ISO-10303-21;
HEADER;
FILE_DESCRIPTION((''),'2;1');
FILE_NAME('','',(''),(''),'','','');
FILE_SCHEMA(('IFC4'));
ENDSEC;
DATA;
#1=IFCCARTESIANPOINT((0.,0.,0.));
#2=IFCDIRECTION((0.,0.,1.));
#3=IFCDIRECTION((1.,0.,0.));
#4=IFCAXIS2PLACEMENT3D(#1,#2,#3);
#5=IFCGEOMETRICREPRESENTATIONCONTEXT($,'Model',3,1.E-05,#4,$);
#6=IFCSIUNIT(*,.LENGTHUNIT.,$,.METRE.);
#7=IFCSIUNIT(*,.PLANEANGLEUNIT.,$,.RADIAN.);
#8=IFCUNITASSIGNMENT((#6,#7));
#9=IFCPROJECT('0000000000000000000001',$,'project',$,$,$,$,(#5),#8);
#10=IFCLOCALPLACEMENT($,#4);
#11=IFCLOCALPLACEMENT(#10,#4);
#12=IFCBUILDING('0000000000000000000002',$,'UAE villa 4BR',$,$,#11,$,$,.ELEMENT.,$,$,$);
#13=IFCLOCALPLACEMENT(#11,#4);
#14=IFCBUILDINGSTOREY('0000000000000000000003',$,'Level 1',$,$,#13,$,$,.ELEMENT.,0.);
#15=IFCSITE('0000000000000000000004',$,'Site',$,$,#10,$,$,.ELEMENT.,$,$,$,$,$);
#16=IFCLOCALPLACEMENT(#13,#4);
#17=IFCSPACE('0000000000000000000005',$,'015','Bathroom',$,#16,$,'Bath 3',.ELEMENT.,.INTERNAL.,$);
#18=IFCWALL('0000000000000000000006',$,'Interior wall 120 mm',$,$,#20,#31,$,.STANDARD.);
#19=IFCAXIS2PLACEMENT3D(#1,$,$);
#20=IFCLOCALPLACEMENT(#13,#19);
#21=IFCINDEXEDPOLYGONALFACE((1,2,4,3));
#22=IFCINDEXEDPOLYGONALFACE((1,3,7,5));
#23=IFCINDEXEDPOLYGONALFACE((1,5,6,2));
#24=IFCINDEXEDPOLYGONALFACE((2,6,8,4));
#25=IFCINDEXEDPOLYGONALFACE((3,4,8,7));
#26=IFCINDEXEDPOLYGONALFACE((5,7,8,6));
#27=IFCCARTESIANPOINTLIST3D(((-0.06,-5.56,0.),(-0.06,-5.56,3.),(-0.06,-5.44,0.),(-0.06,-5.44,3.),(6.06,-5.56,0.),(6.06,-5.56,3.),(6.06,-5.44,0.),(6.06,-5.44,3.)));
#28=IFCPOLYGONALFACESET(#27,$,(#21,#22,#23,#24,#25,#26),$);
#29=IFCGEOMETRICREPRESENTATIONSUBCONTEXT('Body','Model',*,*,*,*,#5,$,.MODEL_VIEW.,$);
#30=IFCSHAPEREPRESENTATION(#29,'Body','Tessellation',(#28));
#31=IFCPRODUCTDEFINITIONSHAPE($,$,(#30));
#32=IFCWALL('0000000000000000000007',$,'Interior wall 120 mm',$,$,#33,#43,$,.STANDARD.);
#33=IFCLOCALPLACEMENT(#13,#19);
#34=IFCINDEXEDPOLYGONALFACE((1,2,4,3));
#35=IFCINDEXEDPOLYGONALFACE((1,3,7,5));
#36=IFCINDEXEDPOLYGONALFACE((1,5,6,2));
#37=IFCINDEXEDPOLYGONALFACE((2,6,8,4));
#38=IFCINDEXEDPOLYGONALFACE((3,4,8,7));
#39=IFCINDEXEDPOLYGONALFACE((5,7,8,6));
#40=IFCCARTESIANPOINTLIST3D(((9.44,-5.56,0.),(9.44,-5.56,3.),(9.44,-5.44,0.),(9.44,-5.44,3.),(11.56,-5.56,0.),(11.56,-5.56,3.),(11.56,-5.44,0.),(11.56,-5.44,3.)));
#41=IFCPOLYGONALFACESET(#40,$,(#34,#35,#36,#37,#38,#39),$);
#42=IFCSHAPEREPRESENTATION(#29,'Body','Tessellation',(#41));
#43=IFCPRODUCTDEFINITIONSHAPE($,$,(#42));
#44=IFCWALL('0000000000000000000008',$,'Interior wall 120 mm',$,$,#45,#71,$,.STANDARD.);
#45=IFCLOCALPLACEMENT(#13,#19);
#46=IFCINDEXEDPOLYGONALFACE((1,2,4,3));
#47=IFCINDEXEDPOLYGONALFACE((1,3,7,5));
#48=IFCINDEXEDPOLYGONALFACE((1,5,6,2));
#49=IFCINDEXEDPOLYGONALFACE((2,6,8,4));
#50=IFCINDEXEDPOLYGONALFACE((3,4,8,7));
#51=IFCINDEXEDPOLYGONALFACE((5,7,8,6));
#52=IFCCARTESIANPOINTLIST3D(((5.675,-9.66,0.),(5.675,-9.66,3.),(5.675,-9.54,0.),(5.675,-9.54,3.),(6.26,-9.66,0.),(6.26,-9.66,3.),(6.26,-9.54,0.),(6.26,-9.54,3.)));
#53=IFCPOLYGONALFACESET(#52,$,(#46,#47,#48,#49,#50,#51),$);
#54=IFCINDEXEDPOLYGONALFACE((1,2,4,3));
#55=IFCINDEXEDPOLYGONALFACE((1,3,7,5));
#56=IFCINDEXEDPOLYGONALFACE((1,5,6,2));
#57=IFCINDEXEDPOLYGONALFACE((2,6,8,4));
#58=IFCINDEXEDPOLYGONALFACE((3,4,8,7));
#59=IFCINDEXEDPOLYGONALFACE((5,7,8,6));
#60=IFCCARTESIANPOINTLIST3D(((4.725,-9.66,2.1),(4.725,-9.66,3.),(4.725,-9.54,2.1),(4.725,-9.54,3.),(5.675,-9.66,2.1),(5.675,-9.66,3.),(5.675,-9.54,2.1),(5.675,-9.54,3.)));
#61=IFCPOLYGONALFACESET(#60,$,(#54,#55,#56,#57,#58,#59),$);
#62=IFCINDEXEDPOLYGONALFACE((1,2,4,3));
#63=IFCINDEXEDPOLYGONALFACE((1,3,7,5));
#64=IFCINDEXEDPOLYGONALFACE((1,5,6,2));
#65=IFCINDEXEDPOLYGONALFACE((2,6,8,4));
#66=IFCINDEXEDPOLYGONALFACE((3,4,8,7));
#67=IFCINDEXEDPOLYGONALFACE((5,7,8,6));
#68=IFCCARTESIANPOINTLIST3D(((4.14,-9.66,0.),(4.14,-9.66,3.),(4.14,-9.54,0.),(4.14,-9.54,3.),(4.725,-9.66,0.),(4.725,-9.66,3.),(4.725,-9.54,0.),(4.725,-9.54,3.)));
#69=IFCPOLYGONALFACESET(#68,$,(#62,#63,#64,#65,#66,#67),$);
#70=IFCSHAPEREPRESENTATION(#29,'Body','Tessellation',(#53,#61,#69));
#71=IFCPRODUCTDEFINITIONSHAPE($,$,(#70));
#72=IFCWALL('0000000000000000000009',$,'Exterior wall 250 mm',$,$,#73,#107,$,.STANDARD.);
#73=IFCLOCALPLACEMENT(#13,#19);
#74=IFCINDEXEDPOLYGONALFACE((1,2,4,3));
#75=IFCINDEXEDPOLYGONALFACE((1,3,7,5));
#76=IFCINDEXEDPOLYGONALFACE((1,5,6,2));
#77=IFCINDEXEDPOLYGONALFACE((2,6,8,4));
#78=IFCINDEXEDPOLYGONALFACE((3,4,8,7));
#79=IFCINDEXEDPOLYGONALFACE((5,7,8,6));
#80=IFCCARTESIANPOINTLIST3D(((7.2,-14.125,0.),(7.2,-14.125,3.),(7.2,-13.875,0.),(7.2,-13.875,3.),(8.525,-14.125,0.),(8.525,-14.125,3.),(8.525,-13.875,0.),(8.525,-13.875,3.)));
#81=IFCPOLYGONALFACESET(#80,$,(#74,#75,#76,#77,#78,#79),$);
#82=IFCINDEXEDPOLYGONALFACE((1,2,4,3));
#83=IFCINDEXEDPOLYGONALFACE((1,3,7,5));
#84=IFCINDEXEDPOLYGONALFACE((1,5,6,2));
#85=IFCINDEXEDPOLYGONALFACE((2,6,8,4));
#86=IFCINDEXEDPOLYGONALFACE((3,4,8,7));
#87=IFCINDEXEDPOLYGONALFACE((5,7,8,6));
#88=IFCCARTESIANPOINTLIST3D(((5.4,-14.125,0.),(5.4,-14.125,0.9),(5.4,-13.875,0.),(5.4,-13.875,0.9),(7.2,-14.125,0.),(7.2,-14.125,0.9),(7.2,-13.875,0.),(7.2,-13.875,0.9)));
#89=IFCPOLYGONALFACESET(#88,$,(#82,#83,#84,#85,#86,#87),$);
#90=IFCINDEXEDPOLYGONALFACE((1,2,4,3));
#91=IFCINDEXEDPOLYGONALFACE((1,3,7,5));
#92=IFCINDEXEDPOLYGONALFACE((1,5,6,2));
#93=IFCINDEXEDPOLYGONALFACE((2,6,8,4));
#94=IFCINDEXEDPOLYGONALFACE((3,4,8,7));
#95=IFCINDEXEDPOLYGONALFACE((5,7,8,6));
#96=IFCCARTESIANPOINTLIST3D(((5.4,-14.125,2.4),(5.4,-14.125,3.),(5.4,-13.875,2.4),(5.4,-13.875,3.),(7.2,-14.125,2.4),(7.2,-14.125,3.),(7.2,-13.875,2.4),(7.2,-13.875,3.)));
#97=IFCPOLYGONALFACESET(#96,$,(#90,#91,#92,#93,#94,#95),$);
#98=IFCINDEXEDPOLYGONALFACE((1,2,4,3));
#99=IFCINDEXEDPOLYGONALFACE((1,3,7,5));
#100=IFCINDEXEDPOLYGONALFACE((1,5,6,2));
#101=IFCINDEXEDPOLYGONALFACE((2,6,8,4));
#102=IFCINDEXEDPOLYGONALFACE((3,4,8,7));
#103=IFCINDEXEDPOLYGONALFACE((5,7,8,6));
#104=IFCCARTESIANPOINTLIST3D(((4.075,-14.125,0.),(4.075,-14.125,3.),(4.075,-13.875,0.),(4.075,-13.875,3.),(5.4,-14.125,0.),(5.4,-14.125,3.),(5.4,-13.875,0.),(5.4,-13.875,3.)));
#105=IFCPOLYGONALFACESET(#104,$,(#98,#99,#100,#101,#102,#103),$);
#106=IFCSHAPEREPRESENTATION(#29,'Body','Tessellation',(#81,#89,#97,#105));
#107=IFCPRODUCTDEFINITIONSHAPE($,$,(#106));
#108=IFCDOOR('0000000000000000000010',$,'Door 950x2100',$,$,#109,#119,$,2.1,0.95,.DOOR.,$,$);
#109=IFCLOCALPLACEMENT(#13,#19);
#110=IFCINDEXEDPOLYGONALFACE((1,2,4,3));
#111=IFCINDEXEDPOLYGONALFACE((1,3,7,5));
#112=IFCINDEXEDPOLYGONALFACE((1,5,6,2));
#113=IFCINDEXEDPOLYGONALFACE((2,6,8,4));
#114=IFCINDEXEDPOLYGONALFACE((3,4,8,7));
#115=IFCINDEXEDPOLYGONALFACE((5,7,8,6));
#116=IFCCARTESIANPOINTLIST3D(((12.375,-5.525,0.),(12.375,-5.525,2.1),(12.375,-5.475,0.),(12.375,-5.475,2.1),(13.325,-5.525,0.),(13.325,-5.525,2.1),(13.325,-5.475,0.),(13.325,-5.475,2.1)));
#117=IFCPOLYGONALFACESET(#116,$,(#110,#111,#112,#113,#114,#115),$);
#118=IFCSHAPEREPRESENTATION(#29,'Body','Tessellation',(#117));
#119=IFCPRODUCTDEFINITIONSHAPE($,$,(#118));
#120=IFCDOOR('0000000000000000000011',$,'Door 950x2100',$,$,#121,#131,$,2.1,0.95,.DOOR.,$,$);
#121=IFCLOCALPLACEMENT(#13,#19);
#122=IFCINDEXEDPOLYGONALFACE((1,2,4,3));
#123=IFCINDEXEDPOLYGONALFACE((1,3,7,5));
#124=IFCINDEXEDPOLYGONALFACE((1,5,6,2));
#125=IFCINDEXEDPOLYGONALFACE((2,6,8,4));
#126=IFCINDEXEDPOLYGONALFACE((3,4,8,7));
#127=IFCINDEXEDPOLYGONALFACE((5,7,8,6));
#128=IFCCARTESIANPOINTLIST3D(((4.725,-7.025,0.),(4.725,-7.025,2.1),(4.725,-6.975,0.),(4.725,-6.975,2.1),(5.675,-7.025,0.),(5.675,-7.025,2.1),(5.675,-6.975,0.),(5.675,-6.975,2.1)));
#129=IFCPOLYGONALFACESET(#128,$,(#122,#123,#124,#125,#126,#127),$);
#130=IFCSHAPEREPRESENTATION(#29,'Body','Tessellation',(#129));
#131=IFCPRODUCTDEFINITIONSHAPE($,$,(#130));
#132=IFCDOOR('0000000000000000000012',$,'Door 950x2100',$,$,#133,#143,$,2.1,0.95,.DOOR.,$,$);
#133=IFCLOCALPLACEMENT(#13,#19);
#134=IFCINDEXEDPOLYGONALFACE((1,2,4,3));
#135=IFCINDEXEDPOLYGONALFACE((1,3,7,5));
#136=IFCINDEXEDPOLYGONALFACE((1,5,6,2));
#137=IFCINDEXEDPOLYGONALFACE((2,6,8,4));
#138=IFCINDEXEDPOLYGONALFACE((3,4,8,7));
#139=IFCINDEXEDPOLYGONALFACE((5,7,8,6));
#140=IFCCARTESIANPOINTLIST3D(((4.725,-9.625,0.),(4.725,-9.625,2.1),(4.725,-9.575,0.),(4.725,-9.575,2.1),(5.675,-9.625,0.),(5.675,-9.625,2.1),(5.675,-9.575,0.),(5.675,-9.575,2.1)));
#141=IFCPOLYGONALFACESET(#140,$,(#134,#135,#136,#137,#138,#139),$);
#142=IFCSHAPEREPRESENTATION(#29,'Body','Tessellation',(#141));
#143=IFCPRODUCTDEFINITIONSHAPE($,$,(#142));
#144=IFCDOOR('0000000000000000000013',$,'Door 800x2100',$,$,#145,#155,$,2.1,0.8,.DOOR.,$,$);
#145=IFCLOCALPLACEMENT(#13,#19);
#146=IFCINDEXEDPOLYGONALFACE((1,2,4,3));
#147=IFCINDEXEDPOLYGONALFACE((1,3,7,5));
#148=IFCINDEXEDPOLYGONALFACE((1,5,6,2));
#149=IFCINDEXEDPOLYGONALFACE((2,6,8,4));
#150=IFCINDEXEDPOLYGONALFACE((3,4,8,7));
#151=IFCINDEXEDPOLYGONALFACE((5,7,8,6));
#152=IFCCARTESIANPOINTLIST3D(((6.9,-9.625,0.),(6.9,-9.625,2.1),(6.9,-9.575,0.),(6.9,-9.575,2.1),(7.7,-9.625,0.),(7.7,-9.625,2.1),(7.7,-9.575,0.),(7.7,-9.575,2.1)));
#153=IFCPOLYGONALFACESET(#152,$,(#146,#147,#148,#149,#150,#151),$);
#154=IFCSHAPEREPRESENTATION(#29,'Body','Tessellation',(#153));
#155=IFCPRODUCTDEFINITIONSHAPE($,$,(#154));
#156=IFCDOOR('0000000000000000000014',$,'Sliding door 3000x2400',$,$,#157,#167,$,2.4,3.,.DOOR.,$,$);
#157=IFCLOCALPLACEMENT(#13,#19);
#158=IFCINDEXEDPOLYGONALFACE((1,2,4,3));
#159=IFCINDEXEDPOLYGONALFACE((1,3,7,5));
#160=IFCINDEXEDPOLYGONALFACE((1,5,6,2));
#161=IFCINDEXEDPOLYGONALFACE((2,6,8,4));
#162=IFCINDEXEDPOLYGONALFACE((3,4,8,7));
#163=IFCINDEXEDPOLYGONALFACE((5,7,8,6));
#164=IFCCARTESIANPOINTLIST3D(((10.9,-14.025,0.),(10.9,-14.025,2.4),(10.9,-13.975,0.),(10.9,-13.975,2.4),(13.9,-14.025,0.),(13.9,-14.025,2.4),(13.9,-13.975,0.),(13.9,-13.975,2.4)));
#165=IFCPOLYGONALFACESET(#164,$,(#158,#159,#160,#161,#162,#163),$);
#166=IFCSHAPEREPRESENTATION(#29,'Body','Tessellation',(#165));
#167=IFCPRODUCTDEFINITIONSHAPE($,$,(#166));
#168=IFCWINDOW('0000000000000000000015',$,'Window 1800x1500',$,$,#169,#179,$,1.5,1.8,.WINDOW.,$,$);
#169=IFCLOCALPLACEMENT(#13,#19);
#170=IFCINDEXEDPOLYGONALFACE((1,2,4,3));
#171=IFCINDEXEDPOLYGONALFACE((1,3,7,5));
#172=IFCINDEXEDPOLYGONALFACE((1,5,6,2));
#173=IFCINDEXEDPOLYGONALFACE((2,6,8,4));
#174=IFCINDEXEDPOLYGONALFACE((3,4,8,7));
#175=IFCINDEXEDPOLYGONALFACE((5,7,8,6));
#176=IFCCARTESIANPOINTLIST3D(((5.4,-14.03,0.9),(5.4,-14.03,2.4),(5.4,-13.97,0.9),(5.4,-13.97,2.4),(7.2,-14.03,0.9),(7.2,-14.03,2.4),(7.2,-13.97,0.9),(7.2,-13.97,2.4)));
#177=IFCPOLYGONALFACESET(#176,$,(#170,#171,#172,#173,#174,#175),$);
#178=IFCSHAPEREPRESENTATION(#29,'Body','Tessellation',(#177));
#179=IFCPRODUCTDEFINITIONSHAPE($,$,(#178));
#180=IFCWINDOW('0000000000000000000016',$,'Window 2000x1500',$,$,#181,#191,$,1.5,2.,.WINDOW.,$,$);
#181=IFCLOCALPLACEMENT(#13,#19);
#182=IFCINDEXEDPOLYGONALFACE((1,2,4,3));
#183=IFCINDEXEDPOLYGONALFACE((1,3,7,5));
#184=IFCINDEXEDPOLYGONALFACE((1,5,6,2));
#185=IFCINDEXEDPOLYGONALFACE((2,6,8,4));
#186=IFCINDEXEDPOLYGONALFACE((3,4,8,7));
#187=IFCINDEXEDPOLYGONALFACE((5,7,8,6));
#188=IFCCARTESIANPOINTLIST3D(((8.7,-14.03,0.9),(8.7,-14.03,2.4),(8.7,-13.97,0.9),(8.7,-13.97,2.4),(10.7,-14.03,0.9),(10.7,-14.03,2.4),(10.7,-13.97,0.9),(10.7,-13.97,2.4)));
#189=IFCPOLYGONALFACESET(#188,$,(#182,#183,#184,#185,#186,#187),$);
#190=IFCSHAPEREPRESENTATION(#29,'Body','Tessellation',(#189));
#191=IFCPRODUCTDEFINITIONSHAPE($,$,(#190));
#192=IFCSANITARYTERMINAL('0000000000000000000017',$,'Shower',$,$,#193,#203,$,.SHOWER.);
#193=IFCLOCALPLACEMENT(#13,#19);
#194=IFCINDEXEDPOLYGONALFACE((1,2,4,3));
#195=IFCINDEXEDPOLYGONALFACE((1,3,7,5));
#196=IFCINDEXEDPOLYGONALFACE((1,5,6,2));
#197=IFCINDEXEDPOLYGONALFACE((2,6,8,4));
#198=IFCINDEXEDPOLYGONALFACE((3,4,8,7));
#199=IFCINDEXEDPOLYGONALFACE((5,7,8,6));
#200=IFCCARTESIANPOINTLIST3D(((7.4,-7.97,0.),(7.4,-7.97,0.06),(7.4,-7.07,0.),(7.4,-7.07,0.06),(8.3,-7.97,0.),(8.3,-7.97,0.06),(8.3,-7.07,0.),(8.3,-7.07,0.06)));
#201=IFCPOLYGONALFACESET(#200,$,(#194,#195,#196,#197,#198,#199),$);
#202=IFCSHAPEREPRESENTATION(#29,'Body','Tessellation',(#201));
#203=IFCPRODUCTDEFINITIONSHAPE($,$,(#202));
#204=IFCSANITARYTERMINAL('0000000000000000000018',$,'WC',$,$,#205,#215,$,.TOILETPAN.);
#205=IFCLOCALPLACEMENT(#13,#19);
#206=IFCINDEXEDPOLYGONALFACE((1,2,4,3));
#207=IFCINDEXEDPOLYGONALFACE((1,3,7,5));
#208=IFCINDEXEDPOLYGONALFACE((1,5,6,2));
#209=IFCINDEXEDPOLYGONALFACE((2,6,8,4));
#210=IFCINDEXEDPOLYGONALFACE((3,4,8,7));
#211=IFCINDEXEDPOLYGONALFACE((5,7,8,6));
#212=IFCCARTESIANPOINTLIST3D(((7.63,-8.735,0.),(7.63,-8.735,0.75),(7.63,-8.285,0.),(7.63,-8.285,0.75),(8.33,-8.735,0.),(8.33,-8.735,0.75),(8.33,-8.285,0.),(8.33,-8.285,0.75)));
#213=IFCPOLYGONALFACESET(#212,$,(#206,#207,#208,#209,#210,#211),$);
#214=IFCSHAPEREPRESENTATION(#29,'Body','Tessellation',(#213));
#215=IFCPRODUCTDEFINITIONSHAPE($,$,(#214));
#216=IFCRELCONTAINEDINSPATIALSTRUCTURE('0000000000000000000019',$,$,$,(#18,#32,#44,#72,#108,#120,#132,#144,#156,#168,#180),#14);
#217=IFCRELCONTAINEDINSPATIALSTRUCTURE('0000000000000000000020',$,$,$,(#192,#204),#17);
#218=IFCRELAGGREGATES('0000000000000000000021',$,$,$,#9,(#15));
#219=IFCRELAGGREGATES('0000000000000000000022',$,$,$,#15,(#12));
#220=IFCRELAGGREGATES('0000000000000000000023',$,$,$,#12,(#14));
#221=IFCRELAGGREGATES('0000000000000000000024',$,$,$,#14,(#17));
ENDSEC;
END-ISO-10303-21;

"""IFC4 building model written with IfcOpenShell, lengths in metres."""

from ifc_helpers import new_model, si_unit, frame, origin, origin_with_axes, origin_2d, place, context, subcontext, project, spatial, rectangle, extrude, element, save


model = new_model("IFC4")

# Units and contexts
model_context = context("Model", 3, precision=1e-05, world=origin_with_axes())
body_context = subcontext(model_context, "Body", "Model", "MODEL_VIEW")
ifc_project = project(units=[si_unit("LENGTHUNIT", "METRE"), si_unit("PLANEANGLEUNIT", "RADIAN")], contexts=[model_context])

# Site, building, storey
site_placement = place(None, origin_with_axes())
site = spatial("IfcSite", under=ifc_project, at=site_placement, Name="Site", CompositionType="ELEMENT")
building_placement = place(site_placement, origin_with_axes())
building = spatial("IfcBuilding", under=site, at=building_placement, Name="UAE villa 4BR", CompositionType="ELEMENT")
storey_placement = place(building_placement, origin_with_axes())
storey = spatial("IfcBuildingStorey", under=building, at=storey_placement, Name="Level 1", CompositionType="ELEMENT", Elevation=0.0)

# Walls
wall_1_placement = place(storey_placement, frame((6.0, -5.5, 0.0), z_axis=(0.0, 0.0, 1.0), x_axis=(-1.0, 0.0, 0.0)))
element("IfcWall", 1, at=wall_1_placement, inside=storey, Name="Interior wall 120 mm", PredefinedType="STANDARD", context=body_context, shape_type="SweptSolid", body=[
    extrude(rectangle(XDim=6.12, YDim=0.12, at=origin_2d()), frame((3.0, 0.0, 0.0)), (0.0, 0.0, 1.0), 3.0),
])
wall_2_placement = place(storey_placement, frame((11.5, -5.5, 0.0), z_axis=(0.0, 0.0, 1.0), x_axis=(-1.0, 0.0, 0.0)))
element("IfcWall", 2, at=wall_2_placement, inside=storey, Name="Interior wall 120 mm", PredefinedType="STANDARD", context=body_context, shape_type="SweptSolid", body=[
    extrude(rectangle(XDim=2.12, YDim=0.12, at=origin_2d()), frame((1.0, 0.0, 0.0)), (0.0, 0.0, 1.0), 3.0),
])
wall_3_placement = place(storey_placement, frame((6.2, -9.6, 0.0), z_axis=(0.0, 0.0, 1.0), x_axis=(-1.0, 0.0, 0.0)))
element("IfcWall", 3, at=wall_3_placement, inside=storey, Name="Interior wall 120 mm", PredefinedType="STANDARD", context=body_context, shape_type="SweptSolid", body=[
    extrude(rectangle(XDim=0.585, YDim=0.12, at=origin_2d()), frame((0.2325, 0.0, 0.0)), (0.0, 0.0, 1.0), 3.0),
    extrude(rectangle(XDim=0.95, YDim=0.12, at=origin_2d()), frame((1.0, 0.0, 2.1)), (0.0, 0.0, 1.0), 0.9),
    extrude(rectangle(XDim=0.585, YDim=0.12, at=origin_2d()), frame((1.7675, 0.0, 0.0)), (0.0, 0.0, 1.0), 3.0),
])
wall_4_placement = place(storey_placement, frame((8.4, -14.0, 0.0), z_axis=(0.0, 0.0, 1.0), x_axis=(-1.0, 0.0, 0.0)))
element("IfcWall", 4, at=wall_4_placement, inside=storey, Name="Exterior wall 250 mm", PredefinedType="STANDARD", context=body_context, shape_type="SweptSolid", body=[
    extrude(rectangle(XDim=1.325, YDim=0.25, at=origin_2d()), frame((0.5375, 0.0, 0.0)), (0.0, 0.0, 1.0), 3.0),
    extrude(rectangle(XDim=1.8, YDim=0.25, at=origin_2d()), frame((2.1, 0.0, 0.0)), (0.0, 0.0, 1.0), 0.9),
    extrude(rectangle(XDim=1.8, YDim=0.25, at=origin_2d()), frame((2.1, 0.0, 2.4)), (0.0, 0.0, 1.0), 0.6),
    extrude(rectangle(XDim=1.325, YDim=0.25, at=origin_2d()), frame((3.6625, 0.0, 0.0)), (0.0, 0.0, 1.0), 3.0),
])

# Doors
for number, where, z_axis, x_axis, name in (
    (5, (12.85, -5.5, 0.0), (0.0, 0.0, 1.0), (-1.0, 0.0, 0.0), "Door 950x2100"),
    (6, (5.2, -7.0, 0.0), (0.0, 0.0, 1.0), (-1.0, 0.0, 0.0), "Door 950x2100"),
    (7, (5.2, -9.6, 0.0), (0.0, 0.0, 1.0), (-1.0, 0.0, 0.0), "Door 950x2100"),
):
    element("IfcDoor", number, at=place(storey_placement, frame(where, z_axis=z_axis, x_axis=x_axis)), inside=storey, Name=name, OverallHeight=2.1, OverallWidth=0.95, PredefinedType="DOOR", context=body_context, shape_type="SweptSolid", body=[
        extrude(rectangle(XDim=0.95, YDim=0.05, at=origin_2d()), origin(), (0.0, 0.0, 1.0), 2.1),
    ])
door_1_placement = place(storey_placement, frame((7.3, -9.6, 0.0), z_axis=(0.0, 0.0, 1.0), x_axis=(-1.0, 0.0, 0.0)))
element("IfcDoor", 8, at=door_1_placement, inside=storey, Name="Door 800x2100", OverallHeight=2.1, OverallWidth=0.8, PredefinedType="DOOR", context=body_context, shape_type="SweptSolid", body=[
    extrude(rectangle(XDim=0.8, YDim=0.05, at=origin_2d()), origin(), (0.0, 0.0, 1.0), 2.1),
])
door_2_placement = place(storey_placement, frame((12.4, -14.0, 0.0), z_axis=(0.0, 0.0, 1.0), x_axis=(-1.0, 0.0, 0.0)))
element("IfcDoor", 9, at=door_2_placement, inside=storey, Name="Sliding door 3000x2400", OverallHeight=2.4, OverallWidth=3.0, PredefinedType="DOOR", context=body_context, shape_type="SweptSolid", body=[
    extrude(rectangle(XDim=3.0, YDim=0.05, at=origin_2d()), origin(), (0.0, 0.0, 1.0), 2.4),
])

# Windows
window_1_placement = place(storey_placement, frame((6.3, -14.0, 0.9), z_axis=(0.0, 0.0, 1.0), x_axis=(-1.0, 0.0, 0.0)))
element("IfcWindow", 10, at=window_1_placement, inside=storey, Name="Window 1800x1500", OverallHeight=1.5, OverallWidth=1.8, PredefinedType="WINDOW", context=body_context, shape_type="SweptSolid", body=[
    extrude(rectangle(XDim=1.8, YDim=0.06, at=origin_2d()), origin(), (0.0, 0.0, 1.0), 1.5),
])
window_2_placement = place(storey_placement, frame((9.7, -14.0, 0.9), z_axis=(0.0, 0.0, 1.0), x_axis=(-1.0, 0.0, 0.0)))
element("IfcWindow", 11, at=window_2_placement, inside=storey, Name="Window 2000x1500", OverallHeight=1.5, OverallWidth=2.0, PredefinedType="WINDOW", context=body_context, shape_type="SweptSolid", body=[
    extrude(rectangle(XDim=2.0, YDim=0.06, at=origin_2d()), origin(), (0.0, 0.0, 1.0), 1.5),
])

# Shared definitions
space_1_placement = place(storey_placement, origin_with_axes())
space_1 = spatial("IfcSpace", under=storey, at=space_1_placement, Name="015", Description="Bathroom", LongName="Bath 3", CompositionType="ELEMENT", PredefinedType="INTERNAL")

# Sanitary terminals
sanitary_terminal_1_placement = place(storey_placement, frame((7.85, -7.52, 0.0), z_axis=(0.0, 0.0, 1.0), x_axis=(1.0, 0.0, 0.0)))
element("IfcSanitaryTerminal", 12, at=sanitary_terminal_1_placement, inside=space_1, Name="Shower", PredefinedType="SHOWER", context=body_context, shape_type="SweptSolid", body=[
    extrude(rectangle(XDim=0.9, YDim=0.9, at=origin_2d()), origin(), (0.0, 0.0, 1.0), 0.06),
])
sanitary_terminal_2_placement = place(storey_placement, frame((7.98, -8.51, 0.0), z_axis=(0.0, 0.0, 1.0), x_axis=(0.0, -1.0, 0.0)))
element("IfcSanitaryTerminal", 13, at=sanitary_terminal_2_placement, inside=space_1, Name="WC", PredefinedType="TOILETPAN", context=body_context, shape_type="SweptSolid", body=[
    extrude(rectangle(XDim=0.45, YDim=0.7, at=origin_2d()), origin(), (0.0, 0.0, 1.0), 0.75),
])

save(model, "model.ifc")
